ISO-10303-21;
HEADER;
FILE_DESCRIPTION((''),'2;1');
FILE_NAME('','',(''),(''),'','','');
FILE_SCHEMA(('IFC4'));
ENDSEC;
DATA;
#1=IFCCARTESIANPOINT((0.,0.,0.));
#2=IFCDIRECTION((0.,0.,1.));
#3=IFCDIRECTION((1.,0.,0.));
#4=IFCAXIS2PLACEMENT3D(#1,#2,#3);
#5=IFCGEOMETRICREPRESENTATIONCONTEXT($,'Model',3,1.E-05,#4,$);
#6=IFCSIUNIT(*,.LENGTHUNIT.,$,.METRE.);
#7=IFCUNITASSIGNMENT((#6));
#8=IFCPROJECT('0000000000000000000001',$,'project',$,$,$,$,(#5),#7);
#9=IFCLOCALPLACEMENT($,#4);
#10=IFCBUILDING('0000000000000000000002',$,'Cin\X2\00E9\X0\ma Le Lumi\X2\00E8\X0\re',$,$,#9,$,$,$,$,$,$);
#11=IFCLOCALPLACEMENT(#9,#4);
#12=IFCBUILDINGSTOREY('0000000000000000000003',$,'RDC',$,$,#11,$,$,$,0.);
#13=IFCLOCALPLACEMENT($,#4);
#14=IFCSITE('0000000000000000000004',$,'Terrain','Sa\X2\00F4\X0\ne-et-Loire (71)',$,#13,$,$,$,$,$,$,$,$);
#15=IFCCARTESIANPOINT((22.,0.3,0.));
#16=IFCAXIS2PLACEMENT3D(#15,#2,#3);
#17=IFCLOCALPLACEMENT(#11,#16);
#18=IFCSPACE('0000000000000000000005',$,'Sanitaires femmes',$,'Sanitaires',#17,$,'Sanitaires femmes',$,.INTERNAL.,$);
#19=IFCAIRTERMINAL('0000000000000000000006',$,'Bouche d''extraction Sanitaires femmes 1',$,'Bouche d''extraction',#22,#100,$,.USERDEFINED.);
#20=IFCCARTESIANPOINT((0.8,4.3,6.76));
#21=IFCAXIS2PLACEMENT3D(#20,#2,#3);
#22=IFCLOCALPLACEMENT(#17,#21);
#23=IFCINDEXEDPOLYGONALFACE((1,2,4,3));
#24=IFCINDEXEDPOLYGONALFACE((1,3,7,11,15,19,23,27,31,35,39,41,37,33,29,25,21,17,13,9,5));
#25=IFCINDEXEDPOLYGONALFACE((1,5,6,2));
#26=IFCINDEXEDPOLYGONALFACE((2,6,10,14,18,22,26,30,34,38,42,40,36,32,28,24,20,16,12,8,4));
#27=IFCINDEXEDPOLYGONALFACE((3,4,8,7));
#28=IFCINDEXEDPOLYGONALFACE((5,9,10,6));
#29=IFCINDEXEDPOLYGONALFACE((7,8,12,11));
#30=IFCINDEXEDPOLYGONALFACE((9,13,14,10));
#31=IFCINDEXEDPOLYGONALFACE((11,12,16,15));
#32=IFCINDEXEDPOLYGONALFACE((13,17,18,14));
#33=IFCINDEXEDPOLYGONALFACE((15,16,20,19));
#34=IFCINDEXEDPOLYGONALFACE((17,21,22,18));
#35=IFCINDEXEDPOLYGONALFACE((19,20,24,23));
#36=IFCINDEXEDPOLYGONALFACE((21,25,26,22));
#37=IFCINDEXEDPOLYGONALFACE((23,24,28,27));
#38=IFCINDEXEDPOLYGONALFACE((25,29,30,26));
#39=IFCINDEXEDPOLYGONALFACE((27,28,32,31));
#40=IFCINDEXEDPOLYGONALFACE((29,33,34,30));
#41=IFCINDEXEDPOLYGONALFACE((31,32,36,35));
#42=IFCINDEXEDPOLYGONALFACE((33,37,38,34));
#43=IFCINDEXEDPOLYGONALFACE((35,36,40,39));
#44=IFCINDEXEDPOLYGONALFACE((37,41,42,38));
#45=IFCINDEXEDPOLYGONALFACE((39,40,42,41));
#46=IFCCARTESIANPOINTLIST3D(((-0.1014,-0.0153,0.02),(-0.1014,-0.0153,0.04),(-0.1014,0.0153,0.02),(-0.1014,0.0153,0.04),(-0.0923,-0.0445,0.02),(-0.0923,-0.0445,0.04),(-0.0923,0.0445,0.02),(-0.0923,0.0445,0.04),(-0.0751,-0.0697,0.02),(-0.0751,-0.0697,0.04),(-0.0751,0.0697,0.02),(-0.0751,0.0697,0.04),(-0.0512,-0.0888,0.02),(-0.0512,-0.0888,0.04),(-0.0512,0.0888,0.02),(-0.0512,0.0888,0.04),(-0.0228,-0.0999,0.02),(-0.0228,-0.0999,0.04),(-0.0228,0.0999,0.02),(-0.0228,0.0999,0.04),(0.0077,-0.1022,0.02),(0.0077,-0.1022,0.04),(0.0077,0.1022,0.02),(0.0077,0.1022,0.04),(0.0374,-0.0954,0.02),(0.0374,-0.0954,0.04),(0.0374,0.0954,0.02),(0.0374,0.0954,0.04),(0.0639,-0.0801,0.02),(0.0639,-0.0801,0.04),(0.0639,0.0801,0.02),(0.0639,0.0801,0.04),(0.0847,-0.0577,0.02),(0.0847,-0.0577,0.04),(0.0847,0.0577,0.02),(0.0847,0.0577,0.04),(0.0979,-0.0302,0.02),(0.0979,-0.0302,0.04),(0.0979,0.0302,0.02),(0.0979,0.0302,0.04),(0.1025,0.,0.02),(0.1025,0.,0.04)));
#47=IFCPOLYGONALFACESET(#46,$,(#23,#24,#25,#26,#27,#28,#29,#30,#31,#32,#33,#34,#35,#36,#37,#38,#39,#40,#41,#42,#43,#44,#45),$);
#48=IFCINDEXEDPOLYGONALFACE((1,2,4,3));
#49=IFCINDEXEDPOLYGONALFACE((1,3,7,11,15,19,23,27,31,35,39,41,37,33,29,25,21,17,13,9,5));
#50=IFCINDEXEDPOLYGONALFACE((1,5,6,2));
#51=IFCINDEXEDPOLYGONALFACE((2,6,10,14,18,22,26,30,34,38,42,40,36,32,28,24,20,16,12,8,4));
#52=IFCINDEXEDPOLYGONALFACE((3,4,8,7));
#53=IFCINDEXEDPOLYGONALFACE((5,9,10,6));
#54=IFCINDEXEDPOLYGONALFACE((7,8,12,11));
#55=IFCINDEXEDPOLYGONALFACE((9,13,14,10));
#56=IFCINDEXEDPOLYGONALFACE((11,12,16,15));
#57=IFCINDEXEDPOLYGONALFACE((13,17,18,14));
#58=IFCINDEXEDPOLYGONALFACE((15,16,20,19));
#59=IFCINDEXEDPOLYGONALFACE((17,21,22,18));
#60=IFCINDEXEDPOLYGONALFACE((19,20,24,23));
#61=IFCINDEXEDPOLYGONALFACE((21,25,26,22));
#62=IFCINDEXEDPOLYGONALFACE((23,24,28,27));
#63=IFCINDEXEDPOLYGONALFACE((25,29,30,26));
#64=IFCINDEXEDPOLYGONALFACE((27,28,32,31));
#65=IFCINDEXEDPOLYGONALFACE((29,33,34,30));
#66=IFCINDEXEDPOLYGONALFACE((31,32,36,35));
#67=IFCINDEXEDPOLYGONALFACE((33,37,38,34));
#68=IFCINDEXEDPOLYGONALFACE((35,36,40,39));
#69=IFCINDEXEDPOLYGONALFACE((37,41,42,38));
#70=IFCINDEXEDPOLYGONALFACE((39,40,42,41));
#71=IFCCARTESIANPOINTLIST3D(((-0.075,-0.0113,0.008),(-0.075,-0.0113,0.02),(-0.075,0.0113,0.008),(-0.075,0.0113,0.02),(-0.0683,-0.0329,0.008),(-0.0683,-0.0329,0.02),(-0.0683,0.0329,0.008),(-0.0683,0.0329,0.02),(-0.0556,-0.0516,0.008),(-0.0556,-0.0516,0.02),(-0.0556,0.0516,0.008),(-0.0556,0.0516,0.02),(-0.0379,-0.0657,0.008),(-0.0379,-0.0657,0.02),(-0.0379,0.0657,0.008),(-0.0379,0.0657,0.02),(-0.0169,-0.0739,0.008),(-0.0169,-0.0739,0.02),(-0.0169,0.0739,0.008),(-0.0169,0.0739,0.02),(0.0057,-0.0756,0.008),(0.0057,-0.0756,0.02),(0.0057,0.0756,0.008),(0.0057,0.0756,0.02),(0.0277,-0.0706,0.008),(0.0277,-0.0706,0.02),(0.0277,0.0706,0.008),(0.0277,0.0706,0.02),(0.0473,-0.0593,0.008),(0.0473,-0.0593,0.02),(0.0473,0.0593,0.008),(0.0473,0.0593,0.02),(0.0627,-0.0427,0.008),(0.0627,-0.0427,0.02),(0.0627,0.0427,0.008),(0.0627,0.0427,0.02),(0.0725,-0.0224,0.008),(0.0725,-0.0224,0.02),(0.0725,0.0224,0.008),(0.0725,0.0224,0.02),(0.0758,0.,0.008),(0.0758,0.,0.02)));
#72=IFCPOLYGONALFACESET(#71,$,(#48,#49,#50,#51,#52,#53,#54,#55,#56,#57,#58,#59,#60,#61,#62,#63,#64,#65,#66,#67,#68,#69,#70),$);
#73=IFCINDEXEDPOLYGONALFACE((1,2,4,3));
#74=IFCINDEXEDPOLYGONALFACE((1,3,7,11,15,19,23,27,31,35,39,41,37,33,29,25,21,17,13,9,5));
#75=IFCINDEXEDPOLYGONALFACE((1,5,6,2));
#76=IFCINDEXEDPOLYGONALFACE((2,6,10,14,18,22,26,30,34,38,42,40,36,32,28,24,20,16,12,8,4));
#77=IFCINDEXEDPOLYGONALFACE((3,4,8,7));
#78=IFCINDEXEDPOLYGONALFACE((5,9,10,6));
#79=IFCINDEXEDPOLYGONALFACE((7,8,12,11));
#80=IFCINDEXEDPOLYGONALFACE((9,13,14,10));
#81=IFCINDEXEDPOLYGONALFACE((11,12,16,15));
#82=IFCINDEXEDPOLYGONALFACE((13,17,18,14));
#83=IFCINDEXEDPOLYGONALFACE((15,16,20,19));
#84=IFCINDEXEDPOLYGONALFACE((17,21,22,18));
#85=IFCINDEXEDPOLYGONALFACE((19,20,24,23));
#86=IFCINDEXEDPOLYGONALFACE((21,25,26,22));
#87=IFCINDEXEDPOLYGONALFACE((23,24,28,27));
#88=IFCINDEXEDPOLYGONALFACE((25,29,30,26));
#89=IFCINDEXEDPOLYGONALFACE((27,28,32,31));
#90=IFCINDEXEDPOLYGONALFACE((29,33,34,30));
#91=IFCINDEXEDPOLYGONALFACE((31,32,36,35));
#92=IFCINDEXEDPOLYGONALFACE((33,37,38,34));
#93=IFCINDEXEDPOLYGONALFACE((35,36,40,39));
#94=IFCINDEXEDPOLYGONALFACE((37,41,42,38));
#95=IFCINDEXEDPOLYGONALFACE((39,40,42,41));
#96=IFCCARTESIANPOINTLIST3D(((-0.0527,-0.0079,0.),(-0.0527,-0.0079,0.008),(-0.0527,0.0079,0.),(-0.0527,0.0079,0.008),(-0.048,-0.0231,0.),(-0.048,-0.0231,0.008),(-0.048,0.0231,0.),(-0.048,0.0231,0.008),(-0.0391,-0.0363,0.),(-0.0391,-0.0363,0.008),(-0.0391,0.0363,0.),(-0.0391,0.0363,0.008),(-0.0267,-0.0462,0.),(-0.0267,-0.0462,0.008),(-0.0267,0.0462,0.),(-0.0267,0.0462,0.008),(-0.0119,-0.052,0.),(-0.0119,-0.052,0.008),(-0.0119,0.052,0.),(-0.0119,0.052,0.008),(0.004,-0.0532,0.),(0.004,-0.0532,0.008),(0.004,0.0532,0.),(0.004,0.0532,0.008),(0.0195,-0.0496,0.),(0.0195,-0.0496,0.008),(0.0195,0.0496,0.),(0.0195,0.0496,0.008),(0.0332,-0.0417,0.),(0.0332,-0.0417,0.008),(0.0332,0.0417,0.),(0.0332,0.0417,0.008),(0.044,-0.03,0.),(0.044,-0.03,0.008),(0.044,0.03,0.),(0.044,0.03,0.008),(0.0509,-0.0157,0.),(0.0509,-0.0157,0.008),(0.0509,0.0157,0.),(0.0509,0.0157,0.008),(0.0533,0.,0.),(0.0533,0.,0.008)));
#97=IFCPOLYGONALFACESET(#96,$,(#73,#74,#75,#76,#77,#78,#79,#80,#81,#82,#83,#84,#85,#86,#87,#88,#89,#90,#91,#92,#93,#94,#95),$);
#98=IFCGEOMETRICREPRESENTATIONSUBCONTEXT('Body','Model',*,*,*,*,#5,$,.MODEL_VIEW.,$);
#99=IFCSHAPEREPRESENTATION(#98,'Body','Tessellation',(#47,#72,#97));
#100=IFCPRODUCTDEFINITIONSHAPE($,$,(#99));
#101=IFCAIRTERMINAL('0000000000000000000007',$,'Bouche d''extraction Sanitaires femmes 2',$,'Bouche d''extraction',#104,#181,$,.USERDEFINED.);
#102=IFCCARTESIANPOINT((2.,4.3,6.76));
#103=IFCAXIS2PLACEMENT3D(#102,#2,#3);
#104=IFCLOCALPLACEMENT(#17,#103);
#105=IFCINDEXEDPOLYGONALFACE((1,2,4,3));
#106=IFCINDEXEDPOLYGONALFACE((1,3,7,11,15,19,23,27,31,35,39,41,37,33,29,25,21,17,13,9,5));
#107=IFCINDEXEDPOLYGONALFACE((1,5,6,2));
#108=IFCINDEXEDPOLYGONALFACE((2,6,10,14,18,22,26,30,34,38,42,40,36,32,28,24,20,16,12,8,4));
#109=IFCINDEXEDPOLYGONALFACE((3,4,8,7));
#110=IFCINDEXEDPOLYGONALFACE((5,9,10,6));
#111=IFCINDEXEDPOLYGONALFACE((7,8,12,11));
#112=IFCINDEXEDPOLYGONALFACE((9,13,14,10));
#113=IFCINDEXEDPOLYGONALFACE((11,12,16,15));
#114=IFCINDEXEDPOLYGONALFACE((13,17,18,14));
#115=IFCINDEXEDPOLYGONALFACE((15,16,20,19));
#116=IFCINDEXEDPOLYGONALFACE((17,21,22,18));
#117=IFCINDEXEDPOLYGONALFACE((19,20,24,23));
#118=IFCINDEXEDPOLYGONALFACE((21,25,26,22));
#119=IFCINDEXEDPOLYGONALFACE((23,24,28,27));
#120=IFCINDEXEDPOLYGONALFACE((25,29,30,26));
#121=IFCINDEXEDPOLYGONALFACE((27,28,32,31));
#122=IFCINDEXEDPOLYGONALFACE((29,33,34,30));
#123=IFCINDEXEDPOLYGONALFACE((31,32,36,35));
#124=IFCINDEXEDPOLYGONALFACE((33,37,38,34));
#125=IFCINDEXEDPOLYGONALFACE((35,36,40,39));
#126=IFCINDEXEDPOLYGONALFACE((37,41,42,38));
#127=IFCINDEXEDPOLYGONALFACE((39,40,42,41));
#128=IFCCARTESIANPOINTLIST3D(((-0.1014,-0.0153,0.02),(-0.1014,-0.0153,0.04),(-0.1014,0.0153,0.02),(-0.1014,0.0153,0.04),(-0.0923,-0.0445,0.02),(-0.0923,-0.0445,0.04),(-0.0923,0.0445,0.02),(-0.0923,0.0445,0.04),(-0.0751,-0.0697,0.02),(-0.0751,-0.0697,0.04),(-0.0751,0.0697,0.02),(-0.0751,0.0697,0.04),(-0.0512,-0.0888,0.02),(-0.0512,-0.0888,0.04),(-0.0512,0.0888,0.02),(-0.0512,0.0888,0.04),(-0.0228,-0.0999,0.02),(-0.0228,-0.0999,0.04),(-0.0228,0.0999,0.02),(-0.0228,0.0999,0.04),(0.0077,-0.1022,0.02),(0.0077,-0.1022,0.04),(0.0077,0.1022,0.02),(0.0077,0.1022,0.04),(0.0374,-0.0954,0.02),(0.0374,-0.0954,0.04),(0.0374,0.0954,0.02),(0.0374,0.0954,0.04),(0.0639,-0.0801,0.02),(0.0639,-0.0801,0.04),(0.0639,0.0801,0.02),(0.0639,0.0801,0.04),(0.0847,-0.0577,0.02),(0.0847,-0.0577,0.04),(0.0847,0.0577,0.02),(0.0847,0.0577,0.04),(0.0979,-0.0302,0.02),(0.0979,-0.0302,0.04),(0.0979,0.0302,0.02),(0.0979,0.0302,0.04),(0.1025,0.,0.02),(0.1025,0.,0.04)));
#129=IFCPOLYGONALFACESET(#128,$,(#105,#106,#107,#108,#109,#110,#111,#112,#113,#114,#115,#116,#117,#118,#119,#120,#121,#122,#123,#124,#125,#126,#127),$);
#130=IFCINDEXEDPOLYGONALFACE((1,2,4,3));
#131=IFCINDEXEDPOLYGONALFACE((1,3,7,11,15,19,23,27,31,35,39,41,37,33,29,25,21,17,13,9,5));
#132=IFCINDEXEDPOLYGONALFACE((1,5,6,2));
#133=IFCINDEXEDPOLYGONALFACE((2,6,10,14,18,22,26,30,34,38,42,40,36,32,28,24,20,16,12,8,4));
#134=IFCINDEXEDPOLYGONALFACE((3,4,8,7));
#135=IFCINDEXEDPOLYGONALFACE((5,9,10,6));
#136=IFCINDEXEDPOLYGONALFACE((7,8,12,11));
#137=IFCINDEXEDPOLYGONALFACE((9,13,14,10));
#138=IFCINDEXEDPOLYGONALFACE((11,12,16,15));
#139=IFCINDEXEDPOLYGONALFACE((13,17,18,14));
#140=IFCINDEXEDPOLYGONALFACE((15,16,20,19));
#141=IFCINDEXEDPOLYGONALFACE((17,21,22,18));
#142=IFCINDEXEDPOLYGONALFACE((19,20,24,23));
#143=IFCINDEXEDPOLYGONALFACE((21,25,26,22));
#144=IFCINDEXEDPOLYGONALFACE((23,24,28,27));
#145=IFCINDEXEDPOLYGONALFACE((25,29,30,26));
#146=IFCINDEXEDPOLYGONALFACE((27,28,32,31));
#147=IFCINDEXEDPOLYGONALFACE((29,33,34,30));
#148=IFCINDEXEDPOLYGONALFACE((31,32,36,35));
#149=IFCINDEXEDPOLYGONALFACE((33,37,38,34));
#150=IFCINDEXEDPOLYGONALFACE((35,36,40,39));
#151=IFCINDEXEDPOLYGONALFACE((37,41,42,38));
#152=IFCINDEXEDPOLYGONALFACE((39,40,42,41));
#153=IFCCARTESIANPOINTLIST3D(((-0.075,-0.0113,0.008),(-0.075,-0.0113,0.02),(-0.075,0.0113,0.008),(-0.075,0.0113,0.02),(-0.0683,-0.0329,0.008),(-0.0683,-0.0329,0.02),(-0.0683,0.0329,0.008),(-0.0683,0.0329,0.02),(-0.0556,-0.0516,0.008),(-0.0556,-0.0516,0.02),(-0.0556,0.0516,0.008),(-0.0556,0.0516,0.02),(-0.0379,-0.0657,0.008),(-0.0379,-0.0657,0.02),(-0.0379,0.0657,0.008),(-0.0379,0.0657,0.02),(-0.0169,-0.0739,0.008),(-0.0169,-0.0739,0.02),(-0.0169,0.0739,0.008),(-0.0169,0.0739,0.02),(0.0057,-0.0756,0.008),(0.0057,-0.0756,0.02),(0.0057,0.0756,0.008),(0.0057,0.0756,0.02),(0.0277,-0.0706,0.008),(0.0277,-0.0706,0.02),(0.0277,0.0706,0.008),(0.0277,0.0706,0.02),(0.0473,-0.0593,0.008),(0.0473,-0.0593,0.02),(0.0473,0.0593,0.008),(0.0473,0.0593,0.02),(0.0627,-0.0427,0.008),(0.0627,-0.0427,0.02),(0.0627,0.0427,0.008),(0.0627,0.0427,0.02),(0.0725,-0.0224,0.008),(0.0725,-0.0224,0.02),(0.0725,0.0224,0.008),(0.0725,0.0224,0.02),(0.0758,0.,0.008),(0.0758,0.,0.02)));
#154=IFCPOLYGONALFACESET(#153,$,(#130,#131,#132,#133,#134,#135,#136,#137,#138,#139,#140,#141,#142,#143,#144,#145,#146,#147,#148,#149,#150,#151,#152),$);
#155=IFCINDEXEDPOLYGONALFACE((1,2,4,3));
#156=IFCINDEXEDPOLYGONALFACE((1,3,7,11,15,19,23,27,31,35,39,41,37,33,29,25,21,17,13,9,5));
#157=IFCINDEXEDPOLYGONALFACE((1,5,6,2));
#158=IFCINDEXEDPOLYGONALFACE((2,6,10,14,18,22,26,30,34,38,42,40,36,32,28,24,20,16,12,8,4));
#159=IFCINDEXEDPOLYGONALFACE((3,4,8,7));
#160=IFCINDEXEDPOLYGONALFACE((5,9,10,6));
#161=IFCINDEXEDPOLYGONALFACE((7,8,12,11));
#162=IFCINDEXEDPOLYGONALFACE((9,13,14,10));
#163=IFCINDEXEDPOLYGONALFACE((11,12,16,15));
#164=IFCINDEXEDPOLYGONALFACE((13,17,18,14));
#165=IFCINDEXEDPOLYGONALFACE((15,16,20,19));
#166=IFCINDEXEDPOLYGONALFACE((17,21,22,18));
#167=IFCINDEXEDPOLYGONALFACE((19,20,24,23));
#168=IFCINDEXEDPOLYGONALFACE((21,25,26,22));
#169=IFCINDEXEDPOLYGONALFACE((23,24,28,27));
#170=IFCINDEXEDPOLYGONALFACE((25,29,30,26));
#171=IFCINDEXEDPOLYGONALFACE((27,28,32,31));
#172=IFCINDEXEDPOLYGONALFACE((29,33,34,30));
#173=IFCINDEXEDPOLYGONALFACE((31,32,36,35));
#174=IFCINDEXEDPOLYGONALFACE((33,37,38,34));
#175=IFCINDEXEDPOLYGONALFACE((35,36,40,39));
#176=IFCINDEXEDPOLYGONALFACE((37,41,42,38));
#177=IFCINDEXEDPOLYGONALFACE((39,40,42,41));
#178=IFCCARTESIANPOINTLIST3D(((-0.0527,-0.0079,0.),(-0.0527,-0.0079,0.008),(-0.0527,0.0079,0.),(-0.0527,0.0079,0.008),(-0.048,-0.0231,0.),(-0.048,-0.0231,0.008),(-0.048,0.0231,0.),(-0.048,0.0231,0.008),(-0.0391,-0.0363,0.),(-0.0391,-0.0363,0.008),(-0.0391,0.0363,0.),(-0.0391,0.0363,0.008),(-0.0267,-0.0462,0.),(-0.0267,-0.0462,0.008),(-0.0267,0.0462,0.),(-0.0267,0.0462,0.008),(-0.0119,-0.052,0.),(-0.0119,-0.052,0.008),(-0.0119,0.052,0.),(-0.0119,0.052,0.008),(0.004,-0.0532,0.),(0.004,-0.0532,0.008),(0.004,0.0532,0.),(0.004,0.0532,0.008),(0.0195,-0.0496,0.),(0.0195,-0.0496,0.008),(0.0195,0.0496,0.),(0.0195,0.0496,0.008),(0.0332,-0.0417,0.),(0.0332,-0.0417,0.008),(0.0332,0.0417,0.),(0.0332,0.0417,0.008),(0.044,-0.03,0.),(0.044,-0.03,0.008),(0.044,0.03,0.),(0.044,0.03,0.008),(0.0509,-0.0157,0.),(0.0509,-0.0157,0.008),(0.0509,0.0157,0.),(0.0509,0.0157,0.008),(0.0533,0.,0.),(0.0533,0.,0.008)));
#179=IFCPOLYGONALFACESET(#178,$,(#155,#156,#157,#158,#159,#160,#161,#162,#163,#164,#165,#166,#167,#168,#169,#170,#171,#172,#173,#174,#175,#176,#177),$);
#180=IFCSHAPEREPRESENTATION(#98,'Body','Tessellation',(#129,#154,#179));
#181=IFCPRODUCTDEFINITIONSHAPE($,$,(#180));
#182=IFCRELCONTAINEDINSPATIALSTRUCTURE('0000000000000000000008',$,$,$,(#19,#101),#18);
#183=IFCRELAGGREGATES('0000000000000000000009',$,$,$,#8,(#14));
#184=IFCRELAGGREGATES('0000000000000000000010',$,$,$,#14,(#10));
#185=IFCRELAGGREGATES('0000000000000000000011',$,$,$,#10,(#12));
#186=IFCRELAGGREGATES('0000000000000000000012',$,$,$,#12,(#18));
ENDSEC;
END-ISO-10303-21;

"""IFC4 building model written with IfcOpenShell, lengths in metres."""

from ifc_helpers import new_model, si_unit, frame, origin_with_axes, place, context, subcontext, project, spatial, circle, extrude, element, save


model = new_model("IFC4")

# Units and contexts
model_context = context("Model", 3, precision=1e-05, world=origin_with_axes())
body_context = subcontext(model_context, "Body", "Model", "MODEL_VIEW")
ifc_project = project(units=[si_unit("LENGTHUNIT", "METRE")], contexts=[model_context])

# Site, building, storey
site_placement = place(None, origin_with_axes())
site = spatial("IfcSite", under=ifc_project, at=site_placement, Name="Terrain", Description="Saône-et-Loire (71)")
building_placement = place(None, origin_with_axes())
building = spatial("IfcBuilding", under=site, at=building_placement, Name="Cinéma Le Lumière")
storey_placement = place(building_placement, origin_with_axes())
storey = spatial("IfcBuildingStorey", under=building, at=storey_placement, Name="RDC", Elevation=0.0)

# Shared definitions
space_1_placement = place(storey_placement, frame((22.0, 0.3, 0.0), z_axis=(0.0, 0.0, 1.0), x_axis=(1.0, 0.0, 0.0)))
space_1 = spatial("IfcSpace", under=storey, at=space_1_placement, Name="Sanitaires femmes", ObjectType="Sanitaires", LongName="Sanitaires femmes", PredefinedType="INTERNAL")

# Air terminal
air_terminal_1_placement = place(space_1_placement, frame((0.8, 4.3, 6.76), z_axis=(0.0, 0.0, 1.0), x_axis=(1.0, 0.0, 0.0)))
element("IfcAirTerminal", 1, at=air_terminal_1_placement, inside=space_1, Name="Bouche d'extraction Sanitaires femmes 1", ObjectType="Bouche d'extraction", PredefinedType="USERDEFINED", context=body_context, shape_type="SweptSolid", body=[
    extrude(circle(Radius=0.1025), frame((0.0, 0.0, 0.02), z_axis=(0.0, 0.0, 1.0), x_axis=(1.0, 0.0, 0.0)), (0.0, 0.0, 1.0), 0.02),
    extrude(circle(Radius=0.0759), frame((0.0, 0.0, 0.008), z_axis=(0.0, 0.0, 1.0), x_axis=(1.0, 0.0, 0.0)), (0.0, 0.0, 1.0), 0.012),
    extrude(circle(Radius=0.0533), origin_with_axes(), (0.0, 0.0, 1.0), 0.008),
])

# Air terminal
air_terminal_2_placement = place(space_1_placement, frame((2.0, 4.3, 6.76), z_axis=(0.0, 0.0, 1.0), x_axis=(1.0, 0.0, 0.0)))
element("IfcAirTerminal", 2, at=air_terminal_2_placement, inside=space_1, Name="Bouche d'extraction Sanitaires femmes 2", ObjectType="Bouche d'extraction", PredefinedType="USERDEFINED", context=body_context, shape_type="SweptSolid", body=[
    extrude(circle(Radius=0.1025), frame((0.0, 0.0, 0.02), z_axis=(0.0, 0.0, 1.0), x_axis=(1.0, 0.0, 0.0)), (0.0, 0.0, 1.0), 0.02),
    extrude(circle(Radius=0.0759), frame((0.0, 0.0, 0.008), z_axis=(0.0, 0.0, 1.0), x_axis=(1.0, 0.0, 0.0)), (0.0, 0.0, 1.0), 0.012),
    extrude(circle(Radius=0.0533), origin_with_axes(), (0.0, 0.0, 1.0), 0.008),
])

save(model, "model.ifc")
